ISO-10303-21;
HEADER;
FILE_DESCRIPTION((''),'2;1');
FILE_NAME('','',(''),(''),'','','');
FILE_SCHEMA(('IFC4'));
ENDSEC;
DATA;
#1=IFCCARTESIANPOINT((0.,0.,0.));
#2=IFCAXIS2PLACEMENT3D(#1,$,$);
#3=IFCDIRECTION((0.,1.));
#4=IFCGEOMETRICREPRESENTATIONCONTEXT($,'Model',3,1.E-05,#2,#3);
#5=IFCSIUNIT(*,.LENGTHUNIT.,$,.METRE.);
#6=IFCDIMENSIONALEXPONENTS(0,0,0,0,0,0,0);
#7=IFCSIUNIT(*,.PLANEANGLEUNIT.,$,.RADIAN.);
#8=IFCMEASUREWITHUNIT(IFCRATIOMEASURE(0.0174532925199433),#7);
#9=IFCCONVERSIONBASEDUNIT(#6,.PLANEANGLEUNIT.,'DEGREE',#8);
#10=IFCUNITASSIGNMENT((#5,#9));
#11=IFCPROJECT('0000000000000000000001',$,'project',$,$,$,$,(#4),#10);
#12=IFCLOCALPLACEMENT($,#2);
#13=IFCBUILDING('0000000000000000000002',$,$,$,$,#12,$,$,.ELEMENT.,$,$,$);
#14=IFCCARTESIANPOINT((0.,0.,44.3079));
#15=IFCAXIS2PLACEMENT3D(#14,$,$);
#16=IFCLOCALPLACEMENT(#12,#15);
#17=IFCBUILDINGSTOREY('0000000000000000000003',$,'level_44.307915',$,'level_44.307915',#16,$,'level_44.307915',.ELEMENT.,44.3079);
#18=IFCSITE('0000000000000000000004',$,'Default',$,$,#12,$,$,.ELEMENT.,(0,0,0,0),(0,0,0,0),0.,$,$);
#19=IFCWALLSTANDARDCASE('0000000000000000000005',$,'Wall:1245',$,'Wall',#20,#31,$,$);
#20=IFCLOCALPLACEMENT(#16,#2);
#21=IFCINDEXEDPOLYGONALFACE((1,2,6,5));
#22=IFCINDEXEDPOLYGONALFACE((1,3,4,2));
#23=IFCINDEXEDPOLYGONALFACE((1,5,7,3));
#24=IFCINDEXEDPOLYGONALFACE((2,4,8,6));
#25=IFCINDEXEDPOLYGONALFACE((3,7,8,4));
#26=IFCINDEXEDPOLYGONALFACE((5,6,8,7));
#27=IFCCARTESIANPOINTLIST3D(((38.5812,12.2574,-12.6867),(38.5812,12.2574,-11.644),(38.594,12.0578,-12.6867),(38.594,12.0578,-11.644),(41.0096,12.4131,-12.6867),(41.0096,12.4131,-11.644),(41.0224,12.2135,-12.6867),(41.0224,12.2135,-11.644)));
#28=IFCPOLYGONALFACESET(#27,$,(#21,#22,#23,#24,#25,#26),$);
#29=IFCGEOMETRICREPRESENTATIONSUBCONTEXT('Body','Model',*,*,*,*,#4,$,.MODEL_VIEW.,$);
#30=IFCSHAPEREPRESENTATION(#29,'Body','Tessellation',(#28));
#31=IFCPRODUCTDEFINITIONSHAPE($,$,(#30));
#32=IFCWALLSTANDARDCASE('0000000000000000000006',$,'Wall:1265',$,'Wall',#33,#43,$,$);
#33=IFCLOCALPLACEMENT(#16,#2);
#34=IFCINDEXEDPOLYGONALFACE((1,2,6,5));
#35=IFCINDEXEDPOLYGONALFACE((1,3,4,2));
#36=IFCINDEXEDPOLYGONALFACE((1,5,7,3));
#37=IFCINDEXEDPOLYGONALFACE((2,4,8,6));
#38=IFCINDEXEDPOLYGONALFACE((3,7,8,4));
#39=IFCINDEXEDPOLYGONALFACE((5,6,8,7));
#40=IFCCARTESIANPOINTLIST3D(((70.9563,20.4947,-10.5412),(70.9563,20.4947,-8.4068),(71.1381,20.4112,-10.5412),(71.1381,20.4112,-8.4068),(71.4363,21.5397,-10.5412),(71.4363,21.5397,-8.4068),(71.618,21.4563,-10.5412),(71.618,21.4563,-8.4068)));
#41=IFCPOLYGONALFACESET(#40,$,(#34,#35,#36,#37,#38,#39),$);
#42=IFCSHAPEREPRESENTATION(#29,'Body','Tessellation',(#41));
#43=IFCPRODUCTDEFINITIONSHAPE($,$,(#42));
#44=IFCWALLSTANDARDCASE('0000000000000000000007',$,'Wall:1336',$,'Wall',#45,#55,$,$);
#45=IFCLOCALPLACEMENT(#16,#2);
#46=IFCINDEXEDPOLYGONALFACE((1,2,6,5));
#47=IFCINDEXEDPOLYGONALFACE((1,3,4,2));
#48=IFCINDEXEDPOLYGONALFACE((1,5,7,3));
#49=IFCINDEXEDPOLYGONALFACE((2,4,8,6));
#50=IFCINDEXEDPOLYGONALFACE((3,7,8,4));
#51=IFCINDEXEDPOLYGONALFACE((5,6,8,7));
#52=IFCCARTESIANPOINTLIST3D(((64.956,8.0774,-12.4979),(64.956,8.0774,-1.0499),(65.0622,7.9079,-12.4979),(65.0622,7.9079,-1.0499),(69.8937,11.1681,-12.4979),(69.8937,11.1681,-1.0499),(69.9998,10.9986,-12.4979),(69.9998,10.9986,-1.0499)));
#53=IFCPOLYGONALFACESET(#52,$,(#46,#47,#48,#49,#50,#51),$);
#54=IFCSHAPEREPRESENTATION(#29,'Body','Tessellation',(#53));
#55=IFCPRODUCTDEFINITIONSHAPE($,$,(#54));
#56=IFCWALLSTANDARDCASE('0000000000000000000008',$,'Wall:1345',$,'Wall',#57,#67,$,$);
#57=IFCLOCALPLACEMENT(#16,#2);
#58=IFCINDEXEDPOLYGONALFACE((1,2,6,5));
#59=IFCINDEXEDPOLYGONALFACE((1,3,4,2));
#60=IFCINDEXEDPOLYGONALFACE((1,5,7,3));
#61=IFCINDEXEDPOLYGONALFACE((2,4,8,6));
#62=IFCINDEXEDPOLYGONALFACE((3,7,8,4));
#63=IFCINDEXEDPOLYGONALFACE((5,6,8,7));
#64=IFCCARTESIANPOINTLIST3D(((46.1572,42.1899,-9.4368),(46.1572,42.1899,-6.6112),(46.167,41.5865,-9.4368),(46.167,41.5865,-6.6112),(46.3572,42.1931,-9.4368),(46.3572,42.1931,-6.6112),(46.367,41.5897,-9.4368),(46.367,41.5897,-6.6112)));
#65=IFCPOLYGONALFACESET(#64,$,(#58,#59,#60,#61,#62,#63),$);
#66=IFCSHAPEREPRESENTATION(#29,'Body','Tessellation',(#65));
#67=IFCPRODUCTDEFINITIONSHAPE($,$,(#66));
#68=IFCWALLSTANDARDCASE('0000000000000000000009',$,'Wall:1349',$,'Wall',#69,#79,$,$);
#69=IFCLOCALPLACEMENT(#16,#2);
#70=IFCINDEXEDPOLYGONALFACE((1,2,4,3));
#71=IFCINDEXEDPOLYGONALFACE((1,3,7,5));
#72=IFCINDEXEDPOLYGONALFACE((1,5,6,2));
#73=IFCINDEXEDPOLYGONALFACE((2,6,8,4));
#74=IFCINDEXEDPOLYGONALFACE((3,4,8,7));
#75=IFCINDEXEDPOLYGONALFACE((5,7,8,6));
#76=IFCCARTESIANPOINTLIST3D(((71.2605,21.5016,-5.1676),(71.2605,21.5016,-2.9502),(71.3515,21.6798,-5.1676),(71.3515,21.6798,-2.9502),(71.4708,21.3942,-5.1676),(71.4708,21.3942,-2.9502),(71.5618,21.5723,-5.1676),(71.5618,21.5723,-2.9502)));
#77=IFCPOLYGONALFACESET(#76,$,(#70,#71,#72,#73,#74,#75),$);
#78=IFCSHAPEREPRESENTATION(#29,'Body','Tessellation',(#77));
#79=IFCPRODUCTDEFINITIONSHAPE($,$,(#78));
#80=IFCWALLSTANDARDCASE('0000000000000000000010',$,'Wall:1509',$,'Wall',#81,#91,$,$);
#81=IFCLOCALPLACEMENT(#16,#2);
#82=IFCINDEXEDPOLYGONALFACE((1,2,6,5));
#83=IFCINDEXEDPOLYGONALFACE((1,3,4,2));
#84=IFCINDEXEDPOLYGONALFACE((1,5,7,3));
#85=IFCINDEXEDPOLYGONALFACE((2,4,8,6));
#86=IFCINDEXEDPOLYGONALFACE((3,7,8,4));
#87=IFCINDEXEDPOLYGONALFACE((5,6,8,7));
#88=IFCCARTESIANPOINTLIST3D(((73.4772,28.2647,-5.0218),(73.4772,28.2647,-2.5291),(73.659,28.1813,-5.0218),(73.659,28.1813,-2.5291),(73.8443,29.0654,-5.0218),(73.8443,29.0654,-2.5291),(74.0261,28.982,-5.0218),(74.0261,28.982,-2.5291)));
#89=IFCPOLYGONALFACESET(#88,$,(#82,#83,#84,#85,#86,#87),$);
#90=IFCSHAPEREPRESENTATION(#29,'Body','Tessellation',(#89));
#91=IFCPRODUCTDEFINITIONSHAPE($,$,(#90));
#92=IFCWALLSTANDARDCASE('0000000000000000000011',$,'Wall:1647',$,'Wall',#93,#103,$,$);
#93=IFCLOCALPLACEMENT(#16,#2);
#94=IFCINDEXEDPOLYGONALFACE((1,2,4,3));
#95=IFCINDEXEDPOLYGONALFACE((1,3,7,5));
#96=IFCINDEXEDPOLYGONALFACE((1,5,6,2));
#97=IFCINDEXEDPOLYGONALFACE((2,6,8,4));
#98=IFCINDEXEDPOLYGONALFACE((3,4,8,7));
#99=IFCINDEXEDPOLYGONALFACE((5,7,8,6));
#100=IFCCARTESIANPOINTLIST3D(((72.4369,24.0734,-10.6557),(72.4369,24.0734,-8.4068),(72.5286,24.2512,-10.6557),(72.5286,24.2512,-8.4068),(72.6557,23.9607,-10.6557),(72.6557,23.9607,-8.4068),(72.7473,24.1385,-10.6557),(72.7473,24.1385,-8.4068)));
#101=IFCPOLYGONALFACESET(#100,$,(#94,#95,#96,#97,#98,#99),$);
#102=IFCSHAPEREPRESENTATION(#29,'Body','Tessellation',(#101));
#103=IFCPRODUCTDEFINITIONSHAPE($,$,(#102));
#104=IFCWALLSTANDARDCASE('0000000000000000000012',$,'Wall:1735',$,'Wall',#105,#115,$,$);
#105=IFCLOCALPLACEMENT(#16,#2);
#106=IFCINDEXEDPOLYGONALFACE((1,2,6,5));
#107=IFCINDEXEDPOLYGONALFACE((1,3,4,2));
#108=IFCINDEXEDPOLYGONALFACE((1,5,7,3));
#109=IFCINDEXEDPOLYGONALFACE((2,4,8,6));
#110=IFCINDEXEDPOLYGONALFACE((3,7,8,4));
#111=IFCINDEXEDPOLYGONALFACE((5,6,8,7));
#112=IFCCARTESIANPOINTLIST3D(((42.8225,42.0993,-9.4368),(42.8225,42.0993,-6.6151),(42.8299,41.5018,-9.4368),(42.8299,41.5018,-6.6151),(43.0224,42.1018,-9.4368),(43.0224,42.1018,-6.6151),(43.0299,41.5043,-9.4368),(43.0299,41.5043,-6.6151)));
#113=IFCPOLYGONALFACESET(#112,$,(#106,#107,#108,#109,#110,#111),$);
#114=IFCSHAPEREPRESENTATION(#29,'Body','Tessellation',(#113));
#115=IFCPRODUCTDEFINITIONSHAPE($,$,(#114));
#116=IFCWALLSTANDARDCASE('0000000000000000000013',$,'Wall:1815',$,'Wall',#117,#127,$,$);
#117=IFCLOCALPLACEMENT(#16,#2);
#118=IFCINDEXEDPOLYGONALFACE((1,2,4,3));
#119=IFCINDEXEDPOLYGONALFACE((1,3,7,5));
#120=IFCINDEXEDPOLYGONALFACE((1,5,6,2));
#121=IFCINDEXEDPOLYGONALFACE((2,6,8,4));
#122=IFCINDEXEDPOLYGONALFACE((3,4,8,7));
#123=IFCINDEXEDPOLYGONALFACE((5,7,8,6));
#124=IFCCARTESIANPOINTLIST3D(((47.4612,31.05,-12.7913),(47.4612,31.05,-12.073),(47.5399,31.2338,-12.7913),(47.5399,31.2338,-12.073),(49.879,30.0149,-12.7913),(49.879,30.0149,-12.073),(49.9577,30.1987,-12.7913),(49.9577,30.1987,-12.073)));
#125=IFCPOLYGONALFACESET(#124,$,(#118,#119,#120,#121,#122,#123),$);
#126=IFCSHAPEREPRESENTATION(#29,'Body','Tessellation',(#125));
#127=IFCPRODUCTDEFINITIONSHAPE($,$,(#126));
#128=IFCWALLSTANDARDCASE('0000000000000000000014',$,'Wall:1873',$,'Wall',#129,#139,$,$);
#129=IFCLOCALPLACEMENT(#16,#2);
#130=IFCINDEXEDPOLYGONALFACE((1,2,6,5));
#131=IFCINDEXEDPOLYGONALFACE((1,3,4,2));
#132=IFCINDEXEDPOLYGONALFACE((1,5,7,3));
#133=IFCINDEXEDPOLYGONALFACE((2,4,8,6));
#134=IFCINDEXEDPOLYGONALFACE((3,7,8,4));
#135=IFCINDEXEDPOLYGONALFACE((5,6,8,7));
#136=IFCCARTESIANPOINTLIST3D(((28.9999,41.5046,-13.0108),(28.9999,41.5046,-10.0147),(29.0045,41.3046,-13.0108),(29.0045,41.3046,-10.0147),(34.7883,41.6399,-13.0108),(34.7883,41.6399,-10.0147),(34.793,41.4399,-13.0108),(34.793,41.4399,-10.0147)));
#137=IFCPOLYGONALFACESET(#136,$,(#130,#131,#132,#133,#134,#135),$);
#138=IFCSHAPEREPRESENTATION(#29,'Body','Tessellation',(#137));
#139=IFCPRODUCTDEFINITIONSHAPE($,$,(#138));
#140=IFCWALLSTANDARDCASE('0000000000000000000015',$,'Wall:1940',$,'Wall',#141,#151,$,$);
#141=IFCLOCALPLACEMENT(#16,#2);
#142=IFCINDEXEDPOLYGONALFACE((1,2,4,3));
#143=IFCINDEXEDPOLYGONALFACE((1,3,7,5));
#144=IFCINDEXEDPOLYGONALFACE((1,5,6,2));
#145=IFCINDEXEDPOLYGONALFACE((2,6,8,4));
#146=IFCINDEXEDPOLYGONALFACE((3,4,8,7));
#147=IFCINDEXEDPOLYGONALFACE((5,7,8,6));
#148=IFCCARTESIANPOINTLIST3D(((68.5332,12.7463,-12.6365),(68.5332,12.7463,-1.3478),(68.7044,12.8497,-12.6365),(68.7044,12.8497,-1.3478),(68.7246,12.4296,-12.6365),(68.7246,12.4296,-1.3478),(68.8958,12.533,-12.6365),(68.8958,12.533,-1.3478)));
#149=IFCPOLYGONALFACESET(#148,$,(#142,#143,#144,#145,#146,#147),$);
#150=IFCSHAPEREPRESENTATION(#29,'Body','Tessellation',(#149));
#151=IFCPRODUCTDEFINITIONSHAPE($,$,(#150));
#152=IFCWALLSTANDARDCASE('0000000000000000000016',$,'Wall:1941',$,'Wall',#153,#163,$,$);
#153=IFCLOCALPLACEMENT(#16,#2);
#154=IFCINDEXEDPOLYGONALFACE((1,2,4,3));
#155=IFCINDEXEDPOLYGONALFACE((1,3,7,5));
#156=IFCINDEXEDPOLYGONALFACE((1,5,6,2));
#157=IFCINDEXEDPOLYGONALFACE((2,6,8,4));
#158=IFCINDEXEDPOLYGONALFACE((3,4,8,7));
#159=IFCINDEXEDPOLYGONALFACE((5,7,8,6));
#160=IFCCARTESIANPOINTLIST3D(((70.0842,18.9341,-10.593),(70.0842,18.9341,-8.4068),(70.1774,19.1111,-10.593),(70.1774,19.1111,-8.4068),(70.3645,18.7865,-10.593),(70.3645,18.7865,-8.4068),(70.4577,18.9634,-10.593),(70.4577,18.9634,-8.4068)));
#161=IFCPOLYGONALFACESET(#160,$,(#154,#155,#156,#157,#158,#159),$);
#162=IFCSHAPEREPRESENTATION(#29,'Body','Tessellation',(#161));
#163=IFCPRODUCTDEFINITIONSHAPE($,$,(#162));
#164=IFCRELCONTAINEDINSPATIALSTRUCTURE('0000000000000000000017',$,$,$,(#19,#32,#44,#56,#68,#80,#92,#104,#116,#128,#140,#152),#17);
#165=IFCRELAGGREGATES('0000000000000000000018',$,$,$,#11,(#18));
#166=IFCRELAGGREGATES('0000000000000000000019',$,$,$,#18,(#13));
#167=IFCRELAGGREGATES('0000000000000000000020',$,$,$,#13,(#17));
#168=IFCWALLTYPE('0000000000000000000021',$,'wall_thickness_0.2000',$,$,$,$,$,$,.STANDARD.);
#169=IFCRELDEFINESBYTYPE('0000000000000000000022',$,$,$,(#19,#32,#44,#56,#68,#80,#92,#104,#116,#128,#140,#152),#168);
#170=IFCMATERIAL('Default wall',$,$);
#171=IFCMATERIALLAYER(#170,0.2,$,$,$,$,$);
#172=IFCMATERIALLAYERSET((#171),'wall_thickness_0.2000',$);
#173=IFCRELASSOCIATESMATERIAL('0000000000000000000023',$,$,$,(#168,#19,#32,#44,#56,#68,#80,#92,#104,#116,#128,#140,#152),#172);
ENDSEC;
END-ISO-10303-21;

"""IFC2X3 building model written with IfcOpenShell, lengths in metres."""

from ifc_helpers import new_model, entity, si_unit, converted_unit, direction, frame, origin, place, context, subcontext, project, spatial, polyline, outline, extrude, material, layer, layer_set, layer_usage, type_object, element, save


model = new_model("IFC2X3")

# Units and contexts
model_context = context("Model", 3, precision=1e-05, world=origin(), true_north=direction((0.0, 1.0)))
body_context = subcontext(model_context, "Body", "Model", "MODEL_VIEW")
ifc_project = project(units=[si_unit("LENGTHUNIT", "METRE"), converted_unit("PLANEANGLEUNIT", "DEGREE", entity("IfcRatioMeasure", 0.0174532925199433), si_unit("PLANEANGLEUNIT", "RADIAN"), dimensions=[0, 0, 0, 0, 0, 0, 0])], contexts=[model_context])

# Site, building, storey
placement_1 = place(None, origin())
site = spatial("IfcSite", under=ifc_project, at=placement_1, Name="Default", CompositionType="ELEMENT", RefLatitude=(0, 0, 0, 0), RefLongitude=(0, 0, 0, 0), RefElevation=0.0)
building = spatial("IfcBuilding", under=site, at=placement_1, CompositionType="ELEMENT")
storey_placement = place(placement_1, frame((0.0, 0.0, 44.3079)))
storey = spatial("IfcBuildingStorey", under=building, at=storey_placement, Name="level_44.307915", ObjectType="level_44.307915", LongName="level_44.307915", CompositionType="ELEMENT", Elevation=44.3079)

# Shared definitions
ifc_material_1 = material(Name="Default wall")
ifc_layer = layer(ifc_material_1, 0.2)
ifc_layer_set = layer_set([ifc_layer], Name="wall_thickness_0.2000")
ifc_layer_usage = layer_usage(ifc_layer_set, "AXIS2", "POSITIVE", -0.1)
wall_type = type_object("IfcWallType", Name="wall_thickness_0.2000", PredefinedType="STANDARD", material=ifc_layer_set)

# Walls
placement_2 = place(placement_1, frame((0.0, 0.0, 31.6212)))
wall_1_placement = place(placement_2, frame((38.5876, 12.1576, 0.0), z_axis=(0.0, 0.0, 1.0), x_axis=(0.997953, 0.063956, 0.0)))
element("IfcWallStandardCase", 1, at=wall_1_placement, inside=storey, type_object=wall_type, material=ifc_layer_usage, Name="Wall:1245", ObjectType="Wall", context=body_context, shape_type="SweptSolid", body=[
    extrude(outline(polyline([(2.4334, -0.1), (2.4334, 0.1), (0.0, 0.1), (0.0, -0.1), (2.4334, -0.1)])), origin(), (0.0, 0.0, 1.0), 1.0427),
])
placement_3 = place(placement_1, frame((0.0, 0.0, 33.7667)))
wall_2_placement = place(placement_3, frame((71.0472, 20.4529, 0.0), z_axis=(0.0, 0.0, 1.0), x_axis=(0.417334, 0.908753, 0.0)))
element("IfcWallStandardCase", 2, at=wall_2_placement, inside=storey, type_object=wall_type, material=ifc_layer_usage, Name="Wall:1265", ObjectType="Wall", context=body_context, shape_type="SweptSolid", body=[
    extrude(outline(polyline([(1.15, -0.1), (1.15, 0.1), (0.0, 0.1), (0.0, -0.1), (1.15, -0.1)])), origin(), (0.0, 0.0, 1.0), 2.1344),
])
placement_4 = place(placement_1, frame((0.0, 0.0, 31.81)))
wall_3_placement = place(placement_4, frame((69.9467, 11.0834, 0.0), z_axis=(0.0, 0.0, 1.0), x_axis=(-0.847635, -0.53058, 0.0)))
element("IfcWallStandardCase", 3, at=wall_3_placement, inside=storey, type_object=wall_type, material=ifc_layer_usage, Name="Wall:1336", ObjectType="Wall", context=body_context, shape_type="SweptSolid", body=[
    extrude(outline(polyline([(5.8252, -0.1), (5.8252, 0.1), (0.0, 0.1), (0.0, -0.1), (5.8252, -0.1)])), origin(), (0.0, 0.0, 1.0), 11.448),
])
placement_5 = place(placement_1, frame((0.0, 0.0, 34.8711)))
wall_4_placement = place(placement_5, frame((46.2572, 42.1915, 0.0), z_axis=(0.0, 0.0, 1.0), x_axis=(0.01622, -0.999868, 0.0)))
element("IfcWallStandardCase", 4, at=wall_4_placement, inside=storey, type_object=wall_type, material=ifc_layer_usage, Name="Wall:1345", ObjectType="Wall", context=body_context, shape_type="SweptSolid", body=[
    extrude(outline(polyline([(0.6035, -0.1), (0.6035, 0.1), (0.0, 0.1), (0.0, -0.1), (0.6035, -0.1)])), origin(), (0.0, 0.0, 1.0), 2.8256),
])
placement_6 = place(placement_1, frame((0.0, 0.0, 39.1403)))
wall_5_placement = place(placement_6, frame((71.5163, 21.4832, 0.0), z_axis=(0.0, 0.0, 1.0), x_axis=(-0.890547, 0.45489, 0.0)))
element("IfcWallStandardCase", 5, at=wall_5_placement, inside=storey, type_object=wall_type, material=ifc_layer_usage, Name="Wall:1349", ObjectType="Wall", context=body_context, shape_type="SweptSolid", body=[
    extrude(outline(polyline([(0.2362, -0.1), (0.2362, 0.1), (0.0, 0.1), (0.0, -0.1), (0.2362, -0.1)])), origin(), (0.0, 0.0, 1.0), 2.2174),
])
placement_7 = place(placement_1, frame((0.0, 0.0, 39.2861)))
wall_6_placement = place(placement_7, frame((73.9352, 29.0237, 0.0), z_axis=(0.0, 0.0, 1.0), x_axis=(-0.416809, -0.908994, 0.0)))
element("IfcWallStandardCase", 6, at=wall_6_placement, inside=storey, type_object=wall_type, material=ifc_layer_usage, Name="Wall:1509", ObjectType="Wall", context=body_context, shape_type="SweptSolid", body=[
    extrude(outline(polyline([(0.8808, -0.1), (0.8808, 0.1), (0.0, 0.1), (0.0, -0.1), (0.8808, -0.1)])), origin(), (0.0, 0.0, 1.0), 2.4927),
])
placement_8 = place(placement_1, frame((0.0, 0.0, 33.6522)))
wall_7_placement = place(placement_8, frame((72.7015, 24.0496, 0.0), z_axis=(0.0, 0.0, 1.0), x_axis=(-0.888908, 0.458086, 0.0)))
element("IfcWallStandardCase", 7, at=wall_7_placement, inside=storey, type_object=wall_type, material=ifc_layer_usage, Name="Wall:1647", ObjectType="Wall", context=body_context, shape_type="SweptSolid", body=[
    extrude(outline(polyline([(0.2461, -0.1), (0.2461, 0.1), (0.0, 0.1), (0.0, -0.1), (0.2461, -0.1)])), origin(), (0.0, 0.0, 1.0), 2.2488),
])
placement_9 = place(placement_1, frame((0.0, 0.0, 34.8711)))
wall_8_placement = place(placement_9, frame((42.9299, 41.5031, 0.0), z_axis=(0.0, 0.0, 1.0), x_axis=(-0.012437, 0.999923, 0.0)))
element("IfcWallStandardCase", 8, at=wall_8_placement, inside=storey, type_object=wall_type, material=ifc_layer_usage, Name="Wall:1735", ObjectType="Wall", context=body_context, shape_type="SweptSolid", body=[
    extrude(outline(polyline([(0.5975, -0.1), (0.5975, 0.1), (0.0, 0.1), (0.0, -0.1), (0.5975, -0.1)])), origin(), (0.0, 0.0, 1.0), 2.8217),
])
placement_10 = place(placement_1, frame((0.0, 0.0, 31.5166)))
wall_9_placement = place(placement_10, frame((47.5006, 31.1419, 0.0), z_axis=(0.0, 0.0, 1.0), x_axis=(0.919296, -0.393568, 0.0)))
element("IfcWallStandardCase", 9, at=wall_9_placement, inside=storey, type_object=wall_type, material=ifc_layer_usage, Name="Wall:1815", ObjectType="Wall", context=body_context, shape_type="SweptSolid", body=[
    extrude(outline(polyline([(2.63, -0.1), (2.63, 0.1), (0.0, 0.1), (0.0, -0.1), (2.63, -0.1)])), origin(), (0.0, 0.0, 1.0), 0.7182),
])
placement_11 = place(placement_1, frame((0.0, 0.0, 31.2971)))
wall_10_placement = place(placement_11, frame((29.0022, 41.4046, 0.0), z_axis=(0.0, 0.0, 1.0), x_axis=(0.999727, 0.023367, 0.0)))
element("IfcWallStandardCase", 10, at=wall_10_placement, inside=storey, type_object=wall_type, material=ifc_layer_usage, Name="Wall:1873", ObjectType="Wall", context=body_context, shape_type="SweptSolid", body=[
    extrude(outline(polyline([(5.79, -0.1), (5.79, 0.1), (0.0, 0.1), (0.0, -0.1), (5.79, -0.1)])), origin(), (0.0, 0.0, 1.0), 2.9961),
])
placement_12 = place(placement_1, frame((0.0, 0.0, 31.6714)))
wall_11_placement = place(placement_12, frame((68.6188, 12.798, 0.0), z_axis=(0.0, 0.0, 1.0), x_axis=(0.517148, -0.855896, 0.0)))
element("IfcWallStandardCase", 11, at=wall_11_placement, inside=storey, type_object=wall_type, material=ifc_layer_usage, Name="Wall:1940", ObjectType="Wall", context=body_context, shape_type="SweptSolid", body=[
    extrude(outline(polyline([(0.37, -0.1), (0.37, 0.1), (0.0, 0.1), (0.0, -0.1), (0.37, -0.1)])), origin(), (0.0, 0.0, 1.0), 11.2886),
])
placement_13 = place(placement_1, frame((0.0, 0.0, 33.7149)))
wall_12_placement = place(placement_13, frame((70.4111, 18.8749, 0.0), z_axis=(0.0, 0.0, 1.0), x_axis=(-0.884733, 0.466099, 0.0)))
element("IfcWallStandardCase", 12, at=wall_12_placement, inside=storey, type_object=wall_type, material=ifc_layer_usage, Name="Wall:1941", ObjectType="Wall", context=body_context, shape_type="SweptSolid", body=[
    extrude(outline(polyline([(0.3168, -0.1), (0.3168, 0.1), (0.0, 0.1), (0.0, -0.1), (0.3168, -0.1)])), origin(), (0.0, 0.0, 1.0), 2.1862),
])

save(model, "model.ifc")
